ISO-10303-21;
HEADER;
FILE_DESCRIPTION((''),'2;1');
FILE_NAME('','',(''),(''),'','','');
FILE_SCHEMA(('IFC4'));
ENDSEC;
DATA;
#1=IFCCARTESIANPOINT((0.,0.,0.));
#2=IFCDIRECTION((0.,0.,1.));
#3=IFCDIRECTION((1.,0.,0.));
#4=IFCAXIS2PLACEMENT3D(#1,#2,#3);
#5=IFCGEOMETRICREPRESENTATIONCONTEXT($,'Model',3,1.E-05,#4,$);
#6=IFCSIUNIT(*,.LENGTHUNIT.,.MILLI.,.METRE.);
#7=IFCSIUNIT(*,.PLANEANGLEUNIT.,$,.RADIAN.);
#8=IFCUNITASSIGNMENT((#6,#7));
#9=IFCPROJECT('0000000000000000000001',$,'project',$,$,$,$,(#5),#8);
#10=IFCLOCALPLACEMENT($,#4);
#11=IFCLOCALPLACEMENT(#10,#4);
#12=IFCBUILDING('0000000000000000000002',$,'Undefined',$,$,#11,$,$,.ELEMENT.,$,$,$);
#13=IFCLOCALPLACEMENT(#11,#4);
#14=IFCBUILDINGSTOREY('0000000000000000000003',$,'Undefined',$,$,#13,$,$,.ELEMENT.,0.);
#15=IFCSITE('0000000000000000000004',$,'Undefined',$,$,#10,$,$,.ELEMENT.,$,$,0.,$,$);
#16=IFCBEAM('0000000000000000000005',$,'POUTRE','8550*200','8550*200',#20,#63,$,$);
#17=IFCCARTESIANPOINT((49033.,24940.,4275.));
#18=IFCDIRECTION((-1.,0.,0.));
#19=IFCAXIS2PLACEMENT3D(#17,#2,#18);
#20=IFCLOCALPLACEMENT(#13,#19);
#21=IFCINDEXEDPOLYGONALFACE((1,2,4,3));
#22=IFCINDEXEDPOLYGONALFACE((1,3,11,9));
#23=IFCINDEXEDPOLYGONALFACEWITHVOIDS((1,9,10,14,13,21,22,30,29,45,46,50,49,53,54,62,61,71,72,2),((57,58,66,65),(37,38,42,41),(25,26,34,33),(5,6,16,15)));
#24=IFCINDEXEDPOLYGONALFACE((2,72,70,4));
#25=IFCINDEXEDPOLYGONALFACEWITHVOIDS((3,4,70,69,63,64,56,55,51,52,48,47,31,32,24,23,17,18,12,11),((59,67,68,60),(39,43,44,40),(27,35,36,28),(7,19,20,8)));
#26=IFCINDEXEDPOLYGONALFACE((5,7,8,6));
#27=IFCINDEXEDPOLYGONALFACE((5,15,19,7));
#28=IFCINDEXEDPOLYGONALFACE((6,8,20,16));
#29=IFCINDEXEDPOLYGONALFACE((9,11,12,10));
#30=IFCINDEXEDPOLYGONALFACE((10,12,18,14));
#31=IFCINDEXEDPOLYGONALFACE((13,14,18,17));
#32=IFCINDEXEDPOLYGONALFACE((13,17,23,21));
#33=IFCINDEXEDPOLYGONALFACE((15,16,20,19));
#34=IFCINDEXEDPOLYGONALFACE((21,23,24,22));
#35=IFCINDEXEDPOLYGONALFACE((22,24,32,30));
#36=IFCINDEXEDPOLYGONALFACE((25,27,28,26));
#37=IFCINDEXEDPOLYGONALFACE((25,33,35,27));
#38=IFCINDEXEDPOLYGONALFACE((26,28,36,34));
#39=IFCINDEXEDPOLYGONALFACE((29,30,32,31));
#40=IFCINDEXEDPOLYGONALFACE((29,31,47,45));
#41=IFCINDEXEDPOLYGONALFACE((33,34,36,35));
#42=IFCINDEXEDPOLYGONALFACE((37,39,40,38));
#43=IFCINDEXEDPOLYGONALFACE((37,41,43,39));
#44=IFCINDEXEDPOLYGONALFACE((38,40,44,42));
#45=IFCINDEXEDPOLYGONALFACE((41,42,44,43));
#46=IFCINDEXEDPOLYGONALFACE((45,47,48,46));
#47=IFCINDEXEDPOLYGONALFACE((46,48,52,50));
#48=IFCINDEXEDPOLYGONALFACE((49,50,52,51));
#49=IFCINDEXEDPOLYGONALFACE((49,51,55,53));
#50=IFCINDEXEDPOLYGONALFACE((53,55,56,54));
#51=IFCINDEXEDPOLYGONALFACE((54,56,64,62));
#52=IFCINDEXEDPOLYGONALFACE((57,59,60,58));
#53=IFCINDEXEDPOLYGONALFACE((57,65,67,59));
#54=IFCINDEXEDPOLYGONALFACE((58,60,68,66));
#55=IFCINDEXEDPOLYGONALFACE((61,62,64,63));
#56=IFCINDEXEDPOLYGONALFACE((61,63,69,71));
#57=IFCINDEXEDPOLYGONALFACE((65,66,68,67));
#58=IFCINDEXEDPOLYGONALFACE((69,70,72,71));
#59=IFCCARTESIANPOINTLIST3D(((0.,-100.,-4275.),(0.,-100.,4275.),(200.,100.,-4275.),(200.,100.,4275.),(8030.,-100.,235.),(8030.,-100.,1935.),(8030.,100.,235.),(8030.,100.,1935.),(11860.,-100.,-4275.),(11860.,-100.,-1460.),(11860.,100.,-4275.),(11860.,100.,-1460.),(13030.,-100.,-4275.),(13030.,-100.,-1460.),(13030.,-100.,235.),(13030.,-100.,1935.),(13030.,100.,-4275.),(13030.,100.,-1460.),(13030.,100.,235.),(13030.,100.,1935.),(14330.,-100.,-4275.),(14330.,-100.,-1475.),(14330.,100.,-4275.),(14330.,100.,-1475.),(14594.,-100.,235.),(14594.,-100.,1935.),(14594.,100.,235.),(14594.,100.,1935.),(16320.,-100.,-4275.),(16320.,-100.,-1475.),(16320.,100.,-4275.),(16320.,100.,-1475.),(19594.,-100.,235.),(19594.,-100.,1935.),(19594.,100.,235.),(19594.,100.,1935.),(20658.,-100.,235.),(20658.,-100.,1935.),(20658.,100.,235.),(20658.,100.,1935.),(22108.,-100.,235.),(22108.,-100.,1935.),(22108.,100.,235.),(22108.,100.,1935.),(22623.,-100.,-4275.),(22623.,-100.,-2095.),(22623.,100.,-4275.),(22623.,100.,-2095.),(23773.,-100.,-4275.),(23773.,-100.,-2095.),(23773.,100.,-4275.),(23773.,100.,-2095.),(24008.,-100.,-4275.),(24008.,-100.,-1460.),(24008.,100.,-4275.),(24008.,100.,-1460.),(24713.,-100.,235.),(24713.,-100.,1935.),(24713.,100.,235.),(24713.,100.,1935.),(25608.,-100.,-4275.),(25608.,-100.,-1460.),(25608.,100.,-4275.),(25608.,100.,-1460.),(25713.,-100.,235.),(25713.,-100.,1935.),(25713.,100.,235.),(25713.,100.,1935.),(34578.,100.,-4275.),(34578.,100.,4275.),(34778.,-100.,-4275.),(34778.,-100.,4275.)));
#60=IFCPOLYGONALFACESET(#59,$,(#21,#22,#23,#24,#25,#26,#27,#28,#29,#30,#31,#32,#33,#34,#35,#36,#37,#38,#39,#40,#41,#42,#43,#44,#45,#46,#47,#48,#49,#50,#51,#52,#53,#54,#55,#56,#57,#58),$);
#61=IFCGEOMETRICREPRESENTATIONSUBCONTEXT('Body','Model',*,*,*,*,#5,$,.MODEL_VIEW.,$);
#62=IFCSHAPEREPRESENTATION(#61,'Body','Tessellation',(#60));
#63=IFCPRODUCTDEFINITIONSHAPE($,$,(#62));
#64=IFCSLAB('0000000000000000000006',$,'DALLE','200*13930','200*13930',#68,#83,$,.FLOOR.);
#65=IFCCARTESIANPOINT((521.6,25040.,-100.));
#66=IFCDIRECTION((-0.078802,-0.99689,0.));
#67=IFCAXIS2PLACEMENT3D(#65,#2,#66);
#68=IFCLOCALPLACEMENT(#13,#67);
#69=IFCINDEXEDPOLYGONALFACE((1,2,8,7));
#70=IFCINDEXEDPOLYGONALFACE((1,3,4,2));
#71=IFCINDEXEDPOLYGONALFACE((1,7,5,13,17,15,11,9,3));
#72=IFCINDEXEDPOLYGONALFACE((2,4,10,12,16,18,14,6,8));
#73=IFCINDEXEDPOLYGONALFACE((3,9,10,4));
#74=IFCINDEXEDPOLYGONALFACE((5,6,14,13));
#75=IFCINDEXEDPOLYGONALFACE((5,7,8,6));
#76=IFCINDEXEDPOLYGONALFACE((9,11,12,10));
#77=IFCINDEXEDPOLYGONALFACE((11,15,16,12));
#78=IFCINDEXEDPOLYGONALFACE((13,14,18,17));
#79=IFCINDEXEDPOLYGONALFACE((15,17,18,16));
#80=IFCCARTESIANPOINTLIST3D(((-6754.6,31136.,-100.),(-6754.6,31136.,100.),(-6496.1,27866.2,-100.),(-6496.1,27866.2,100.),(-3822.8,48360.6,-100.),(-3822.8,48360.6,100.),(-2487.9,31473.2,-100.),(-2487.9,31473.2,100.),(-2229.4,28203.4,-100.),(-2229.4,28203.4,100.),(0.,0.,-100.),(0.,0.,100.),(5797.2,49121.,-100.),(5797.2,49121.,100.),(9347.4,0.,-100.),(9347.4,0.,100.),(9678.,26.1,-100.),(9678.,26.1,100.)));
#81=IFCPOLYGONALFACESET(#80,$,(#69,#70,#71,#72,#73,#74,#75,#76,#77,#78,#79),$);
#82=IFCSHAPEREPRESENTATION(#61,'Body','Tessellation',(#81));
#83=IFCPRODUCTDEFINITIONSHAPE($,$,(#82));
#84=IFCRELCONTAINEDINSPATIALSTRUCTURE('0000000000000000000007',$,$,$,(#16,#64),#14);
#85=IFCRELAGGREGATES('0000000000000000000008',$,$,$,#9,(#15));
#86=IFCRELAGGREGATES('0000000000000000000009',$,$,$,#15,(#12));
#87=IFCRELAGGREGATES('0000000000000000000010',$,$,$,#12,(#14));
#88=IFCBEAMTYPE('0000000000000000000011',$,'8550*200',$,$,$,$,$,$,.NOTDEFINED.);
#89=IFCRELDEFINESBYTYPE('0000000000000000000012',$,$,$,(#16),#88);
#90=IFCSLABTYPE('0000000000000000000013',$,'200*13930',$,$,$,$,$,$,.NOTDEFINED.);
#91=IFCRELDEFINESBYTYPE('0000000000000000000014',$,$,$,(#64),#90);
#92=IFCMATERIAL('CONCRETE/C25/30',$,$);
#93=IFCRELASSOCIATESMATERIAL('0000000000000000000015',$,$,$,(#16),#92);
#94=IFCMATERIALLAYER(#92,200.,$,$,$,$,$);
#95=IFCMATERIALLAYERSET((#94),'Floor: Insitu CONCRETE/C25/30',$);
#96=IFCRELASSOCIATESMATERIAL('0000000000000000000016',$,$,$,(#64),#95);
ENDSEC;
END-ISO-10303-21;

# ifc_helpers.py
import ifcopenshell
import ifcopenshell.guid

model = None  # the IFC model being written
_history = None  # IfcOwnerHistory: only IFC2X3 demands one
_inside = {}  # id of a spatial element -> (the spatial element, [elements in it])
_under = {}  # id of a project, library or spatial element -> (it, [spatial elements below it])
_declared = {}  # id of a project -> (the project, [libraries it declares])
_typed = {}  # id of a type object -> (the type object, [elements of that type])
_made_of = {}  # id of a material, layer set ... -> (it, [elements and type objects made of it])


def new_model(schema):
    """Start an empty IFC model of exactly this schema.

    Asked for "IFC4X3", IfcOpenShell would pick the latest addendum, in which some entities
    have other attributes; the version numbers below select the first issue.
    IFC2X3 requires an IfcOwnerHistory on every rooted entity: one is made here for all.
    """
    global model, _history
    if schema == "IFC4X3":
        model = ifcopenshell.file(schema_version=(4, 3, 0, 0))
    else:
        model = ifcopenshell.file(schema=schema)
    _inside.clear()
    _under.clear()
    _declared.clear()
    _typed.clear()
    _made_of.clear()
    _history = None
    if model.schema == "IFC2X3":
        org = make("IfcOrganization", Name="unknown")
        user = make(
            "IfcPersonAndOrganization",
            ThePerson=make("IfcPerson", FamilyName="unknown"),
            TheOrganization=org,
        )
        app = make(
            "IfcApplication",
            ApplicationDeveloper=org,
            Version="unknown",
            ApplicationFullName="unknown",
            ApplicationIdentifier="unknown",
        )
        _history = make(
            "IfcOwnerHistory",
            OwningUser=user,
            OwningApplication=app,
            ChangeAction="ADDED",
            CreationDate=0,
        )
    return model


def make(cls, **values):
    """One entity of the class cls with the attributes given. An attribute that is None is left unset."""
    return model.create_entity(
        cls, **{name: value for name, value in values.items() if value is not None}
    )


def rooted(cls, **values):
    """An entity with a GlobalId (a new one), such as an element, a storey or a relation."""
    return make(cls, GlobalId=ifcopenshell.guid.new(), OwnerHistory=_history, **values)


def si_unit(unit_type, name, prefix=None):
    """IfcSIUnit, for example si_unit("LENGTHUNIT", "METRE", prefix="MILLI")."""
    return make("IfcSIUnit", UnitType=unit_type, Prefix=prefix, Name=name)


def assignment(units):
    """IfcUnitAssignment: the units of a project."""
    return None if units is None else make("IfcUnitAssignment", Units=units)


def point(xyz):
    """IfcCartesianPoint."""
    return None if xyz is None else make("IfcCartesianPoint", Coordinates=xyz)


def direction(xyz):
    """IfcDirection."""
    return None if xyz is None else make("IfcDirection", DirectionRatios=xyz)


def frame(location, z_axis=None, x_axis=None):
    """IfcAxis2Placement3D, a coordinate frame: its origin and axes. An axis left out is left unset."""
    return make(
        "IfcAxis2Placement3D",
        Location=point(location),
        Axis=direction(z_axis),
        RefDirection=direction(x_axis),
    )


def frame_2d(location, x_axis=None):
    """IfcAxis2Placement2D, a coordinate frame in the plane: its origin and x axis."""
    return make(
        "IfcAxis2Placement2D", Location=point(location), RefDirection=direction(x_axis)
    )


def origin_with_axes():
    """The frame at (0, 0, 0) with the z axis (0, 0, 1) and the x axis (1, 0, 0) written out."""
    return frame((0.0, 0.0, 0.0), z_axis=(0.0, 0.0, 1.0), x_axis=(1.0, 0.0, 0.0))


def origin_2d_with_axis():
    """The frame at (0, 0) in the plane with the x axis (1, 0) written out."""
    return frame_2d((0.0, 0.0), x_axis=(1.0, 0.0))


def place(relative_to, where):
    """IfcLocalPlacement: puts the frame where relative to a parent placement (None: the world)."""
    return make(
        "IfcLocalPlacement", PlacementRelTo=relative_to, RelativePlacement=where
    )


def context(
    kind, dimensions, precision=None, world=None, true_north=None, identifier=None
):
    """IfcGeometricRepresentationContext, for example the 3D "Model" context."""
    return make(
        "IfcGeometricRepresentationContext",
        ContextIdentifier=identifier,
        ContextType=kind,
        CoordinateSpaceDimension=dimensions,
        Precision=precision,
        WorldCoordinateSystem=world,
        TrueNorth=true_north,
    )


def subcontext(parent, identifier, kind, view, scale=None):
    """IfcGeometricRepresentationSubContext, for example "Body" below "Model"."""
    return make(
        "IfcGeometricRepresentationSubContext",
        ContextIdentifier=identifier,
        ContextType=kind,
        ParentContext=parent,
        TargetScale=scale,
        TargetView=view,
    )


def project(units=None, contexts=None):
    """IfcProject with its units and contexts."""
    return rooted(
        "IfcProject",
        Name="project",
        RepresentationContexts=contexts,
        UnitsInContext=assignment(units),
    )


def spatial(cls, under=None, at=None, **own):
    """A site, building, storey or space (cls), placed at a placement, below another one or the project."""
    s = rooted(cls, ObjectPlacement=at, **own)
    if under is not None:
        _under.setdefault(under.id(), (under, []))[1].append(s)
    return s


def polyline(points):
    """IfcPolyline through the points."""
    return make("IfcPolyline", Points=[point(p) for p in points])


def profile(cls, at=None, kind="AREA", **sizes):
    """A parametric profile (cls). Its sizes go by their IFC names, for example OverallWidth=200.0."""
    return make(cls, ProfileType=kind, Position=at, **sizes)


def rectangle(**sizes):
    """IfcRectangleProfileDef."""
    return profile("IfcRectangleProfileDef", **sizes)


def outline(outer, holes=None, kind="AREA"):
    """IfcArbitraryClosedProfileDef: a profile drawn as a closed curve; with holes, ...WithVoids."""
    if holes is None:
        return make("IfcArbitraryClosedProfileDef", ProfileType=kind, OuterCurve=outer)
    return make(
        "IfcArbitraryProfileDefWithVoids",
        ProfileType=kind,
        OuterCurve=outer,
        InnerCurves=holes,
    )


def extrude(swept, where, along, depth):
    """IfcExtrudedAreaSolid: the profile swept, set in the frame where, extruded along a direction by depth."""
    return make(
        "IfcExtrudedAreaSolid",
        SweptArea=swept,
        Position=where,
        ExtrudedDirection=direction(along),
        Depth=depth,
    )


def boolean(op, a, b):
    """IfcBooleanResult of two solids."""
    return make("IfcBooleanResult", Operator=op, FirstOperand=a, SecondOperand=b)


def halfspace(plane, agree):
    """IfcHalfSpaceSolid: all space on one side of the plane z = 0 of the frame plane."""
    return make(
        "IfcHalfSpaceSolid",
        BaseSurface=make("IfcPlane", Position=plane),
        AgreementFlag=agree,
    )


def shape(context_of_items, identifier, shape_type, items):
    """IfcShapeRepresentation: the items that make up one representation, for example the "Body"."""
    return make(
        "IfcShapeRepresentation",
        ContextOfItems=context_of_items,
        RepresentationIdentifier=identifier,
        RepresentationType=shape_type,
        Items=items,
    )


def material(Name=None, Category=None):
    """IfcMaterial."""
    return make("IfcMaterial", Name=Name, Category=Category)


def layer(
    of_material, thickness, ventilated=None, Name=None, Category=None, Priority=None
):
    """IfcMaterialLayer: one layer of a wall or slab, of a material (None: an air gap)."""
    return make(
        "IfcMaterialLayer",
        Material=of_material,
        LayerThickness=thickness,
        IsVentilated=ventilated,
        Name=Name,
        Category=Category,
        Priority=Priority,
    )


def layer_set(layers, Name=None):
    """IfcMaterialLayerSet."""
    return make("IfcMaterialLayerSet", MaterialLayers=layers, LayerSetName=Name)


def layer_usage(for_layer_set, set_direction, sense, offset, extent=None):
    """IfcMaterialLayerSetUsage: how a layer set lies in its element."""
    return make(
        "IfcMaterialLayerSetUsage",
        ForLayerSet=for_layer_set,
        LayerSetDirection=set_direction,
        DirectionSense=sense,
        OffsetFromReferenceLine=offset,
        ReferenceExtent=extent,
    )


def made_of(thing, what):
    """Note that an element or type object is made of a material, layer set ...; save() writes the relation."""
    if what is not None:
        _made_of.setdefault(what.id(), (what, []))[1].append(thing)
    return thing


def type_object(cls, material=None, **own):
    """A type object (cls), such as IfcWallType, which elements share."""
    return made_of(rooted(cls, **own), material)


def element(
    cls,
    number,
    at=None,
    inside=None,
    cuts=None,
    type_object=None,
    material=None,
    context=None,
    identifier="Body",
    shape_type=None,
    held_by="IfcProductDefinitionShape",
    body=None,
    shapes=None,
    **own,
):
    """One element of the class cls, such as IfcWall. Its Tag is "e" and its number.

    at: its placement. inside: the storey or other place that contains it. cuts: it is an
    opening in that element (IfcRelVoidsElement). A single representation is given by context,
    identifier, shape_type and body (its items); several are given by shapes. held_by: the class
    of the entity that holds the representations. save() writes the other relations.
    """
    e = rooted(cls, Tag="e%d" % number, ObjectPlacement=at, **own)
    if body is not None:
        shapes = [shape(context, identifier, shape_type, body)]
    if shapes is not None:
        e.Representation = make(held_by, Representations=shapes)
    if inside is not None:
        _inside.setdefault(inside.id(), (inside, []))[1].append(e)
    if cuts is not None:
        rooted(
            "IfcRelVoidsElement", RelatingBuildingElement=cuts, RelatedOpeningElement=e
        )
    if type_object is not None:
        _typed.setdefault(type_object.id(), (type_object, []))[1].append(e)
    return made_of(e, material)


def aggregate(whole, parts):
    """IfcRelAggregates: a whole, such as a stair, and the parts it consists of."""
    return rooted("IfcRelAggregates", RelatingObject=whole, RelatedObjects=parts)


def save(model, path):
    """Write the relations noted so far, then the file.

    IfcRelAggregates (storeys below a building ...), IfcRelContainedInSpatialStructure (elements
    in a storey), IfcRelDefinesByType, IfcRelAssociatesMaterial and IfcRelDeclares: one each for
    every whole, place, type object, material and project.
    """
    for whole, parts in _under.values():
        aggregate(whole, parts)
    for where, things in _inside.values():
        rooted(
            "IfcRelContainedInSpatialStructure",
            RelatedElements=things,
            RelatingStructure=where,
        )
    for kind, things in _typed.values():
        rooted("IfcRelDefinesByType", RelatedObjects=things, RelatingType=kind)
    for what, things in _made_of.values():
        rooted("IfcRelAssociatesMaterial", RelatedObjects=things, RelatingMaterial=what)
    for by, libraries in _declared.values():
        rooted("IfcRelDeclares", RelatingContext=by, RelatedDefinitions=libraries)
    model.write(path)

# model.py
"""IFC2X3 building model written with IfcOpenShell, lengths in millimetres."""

from ifc_helpers import new_model, si_unit, frame, origin_with_axes, origin_2d_with_axis, place, context, subcontext, project, spatial, polyline, rectangle, outline, extrude, boolean, halfspace, material, layer, layer_set, layer_usage, type_object, element, save


model = new_model("IFC2X3")

# Units and contexts
model_context = context("Model", 3, precision=1e-05, world=origin_with_axes())
body_context = subcontext(model_context, "Body", "Model", "MODEL_VIEW")
ifc_project = project(units=[si_unit("LENGTHUNIT", "METRE", prefix="MILLI"), si_unit("PLANEANGLEUNIT", "RADIAN")], contexts=[model_context])

# Site, building, storey
site_placement = place(None, origin_with_axes())
site = spatial("IfcSite", under=ifc_project, at=site_placement, Name="Undefined", CompositionType="ELEMENT", RefElevation=0.0)
building_placement = place(site_placement, origin_with_axes())
building = spatial("IfcBuilding", under=site, at=building_placement, Name="Undefined", CompositionType="ELEMENT")
storey_placement = place(building_placement, origin_with_axes())
storey = spatial("IfcBuildingStorey", under=building, at=storey_placement, Name="Undefined", CompositionType="ELEMENT", Elevation=0.0)

# Beam
ifc_material_1 = material(Name="CONCRETE/C25/30")
beam_type_1 = type_object("IfcBeamType", Name="8550*200", PredefinedType="NOTDEFINED")
beam_1_placement = place(storey_placement, frame((49033.0, 24940.0, 4275.0), z_axis=(0.0, 0.0, 1.0), x_axis=(-1.0, 0.0, 0.0)))
solid = boolean("DIFFERENCE", boolean("DIFFERENCE", boolean("DIFFERENCE", boolean("DIFFERENCE", boolean("DIFFERENCE", boolean("DIFFERENCE", boolean("DIFFERENCE", boolean("DIFFERENCE", extrude(rectangle(XDim=200.0, YDim=8550.0, at=origin_2d_with_axis()), frame((34880.0, 0.0, 0.0), z_axis=(-1.0, 0.0, 0.0), x_axis=(0.0, -1.0, 0.0)), (0.0, 0.0, 1.0), 34982.0), extrude(outline(polyline([(0.0, 0.0), (1700.0, 0.0), (1700.0, 1000.0), (0.0, 1000.0), (0.0, 0.0)])), frame((24713.0, 103.0, 1935.0), z_axis=(0.0, -1.0, 0.0), x_axis=(0.0, 0.0, -1.0)), (0.0, 0.0, 1.0), 206.0)), extrude(outline(polyline([(0.0, 0.0), (1700.0, 0.0), (1700.0, 1450.0), (0.0, 1450.0), (0.0, 0.0)])), frame((20658.0, 103.0, 1935.0), z_axis=(0.0, -1.0, 0.0), x_axis=(0.0, 0.0, -1.0)), (0.0, 0.0, 1.0), 206.0)), extrude(outline(polyline([(0.0, 0.0), (1700.0, 0.0), (1700.0, 5000.0), (0.0, 5000.0), (0.0, 0.0)])), frame((14594.0, 103.0, 1935.0), z_axis=(0.0, -1.0, 0.0), x_axis=(0.0, 0.0, -1.0)), (0.0, 0.0, 1.0), 206.0)), extrude(outline(polyline([(0.0, 0.0), (1700.0, 0.0), (1700.0, 5000.0), (0.0, 5000.0), (0.0, 0.0)])), frame((13030.0, -103.0, 1935.0), z_axis=(0.0, 1.0, 0.0), x_axis=(0.0, 0.0, -1.0)), (0.0, 0.0, 1.0), 206.0)), extrude(outline(polyline([(0.0, 0.0), (1600.0, 0.0), (1600.0, 2815.0), (0.0, 2815.0), (0.0, 0.0)])), frame((24008.0, -103.0, -1460.0), z_axis=(0.0, 1.0, 0.0), x_axis=(1.0, 0.0, 0.0)), (0.0, 0.0, 1.0), 206.0)), extrude(outline(polyline([(0.0, 0.0), (1170.0, 0.0), (1170.0, 2815.0), (0.0, 2815.0), (0.0, 0.0)])), frame((11860.0, -103.0, -1460.0), z_axis=(0.0, 1.0, 0.0), x_axis=(1.0, 0.0, 0.0)), (0.0, 0.0, 1.0), 206.0)), extrude(outline(polyline([(0.0, 0.0), (1990.0, 0.0), (1990.0, 2800.0), (0.0, 2800.0), (0.0, 0.0)])), frame((14330.0, -103.0, -1475.0), z_axis=(0.0, 1.0, 0.0), x_axis=(1.0, 0.0, 0.0)), (0.0, 0.0, 1.0), 206.0)), extrude(outline(polyline([(0.0, 0.0), (1150.0, 0.0), (1150.0, 2180.0), (0.0, 2180.0), (0.0, 0.0)])), frame((22623.0, -103.0, -2095.0), z_axis=(0.0, 1.0, 0.0), x_axis=(1.0, 0.0, 0.0)), (0.0, 0.0, 1.0), 206.0))
element("IfcBeam", 1, at=beam_1_placement, inside=storey, type_object=beam_type_1, material=ifc_material_1, Name="POUTRE", Description="8550*200", ObjectType="8550*200", context=body_context, shape_type="CSG", body=[
    boolean("DIFFERENCE", boolean("DIFFERENCE", solid, halfspace(frame((34778.0, -100.0, -4275.0), z_axis=(0.707107, 0.707107, 0.0), x_axis=(0.0, 0.0, 1.0)), False)), halfspace(frame((0.0, -100.0, -4275.0), z_axis=(0.707107, -0.707107, 0.0), x_axis=(0.0, 0.0, 1.0)), True)),
])

# Slab
ifc_layer_1 = layer(ifc_material_1, 200.0)
ifc_layer_set_1 = layer_set([ifc_layer_1], Name="Floor: Insitu CONCRETE/C25/30")
ifc_layer_usage_1 = layer_usage(ifc_layer_set_1, "AXIS3", "POSITIVE", -100.0)
slab_type_1 = type_object("IfcSlabType", Name="200*13930", PredefinedType="NOTDEFINED")
slab_1_placement = place(storey_placement, frame((521.6, 25040.0, -100.0), z_axis=(0.0, 0.0, 1.0), x_axis=(-0.078802, -0.99689, 0.0)))
element("IfcSlab", 2, at=slab_1_placement, inside=storey, type_object=slab_type_1, material=ifc_layer_usage_1, Name="DALLE", Description="200*13930", ObjectType="200*13930", PredefinedType="FLOOR", context=body_context, shape_type="SweptSolid", body=[
    extrude(outline(polyline([(0.0, 0.0), (9347.4, 0.0), (9678.0, 26.1), (5797.2, 49121.0), (-3822.8, 48360.6), (-2487.9, 31473.2), (-6754.6, 31136.0), (-6496.1, 27866.2), (-2229.4, 28203.4), (0.0, 0.0)])), frame((0.0, 0.0, -100.0), z_axis=(0.0, 0.0, 1.0), x_axis=(1.0, 0.0, 0.0)), (0.0, 0.0, 1.0), 200.0),
])

save(model, "model.ifc")
